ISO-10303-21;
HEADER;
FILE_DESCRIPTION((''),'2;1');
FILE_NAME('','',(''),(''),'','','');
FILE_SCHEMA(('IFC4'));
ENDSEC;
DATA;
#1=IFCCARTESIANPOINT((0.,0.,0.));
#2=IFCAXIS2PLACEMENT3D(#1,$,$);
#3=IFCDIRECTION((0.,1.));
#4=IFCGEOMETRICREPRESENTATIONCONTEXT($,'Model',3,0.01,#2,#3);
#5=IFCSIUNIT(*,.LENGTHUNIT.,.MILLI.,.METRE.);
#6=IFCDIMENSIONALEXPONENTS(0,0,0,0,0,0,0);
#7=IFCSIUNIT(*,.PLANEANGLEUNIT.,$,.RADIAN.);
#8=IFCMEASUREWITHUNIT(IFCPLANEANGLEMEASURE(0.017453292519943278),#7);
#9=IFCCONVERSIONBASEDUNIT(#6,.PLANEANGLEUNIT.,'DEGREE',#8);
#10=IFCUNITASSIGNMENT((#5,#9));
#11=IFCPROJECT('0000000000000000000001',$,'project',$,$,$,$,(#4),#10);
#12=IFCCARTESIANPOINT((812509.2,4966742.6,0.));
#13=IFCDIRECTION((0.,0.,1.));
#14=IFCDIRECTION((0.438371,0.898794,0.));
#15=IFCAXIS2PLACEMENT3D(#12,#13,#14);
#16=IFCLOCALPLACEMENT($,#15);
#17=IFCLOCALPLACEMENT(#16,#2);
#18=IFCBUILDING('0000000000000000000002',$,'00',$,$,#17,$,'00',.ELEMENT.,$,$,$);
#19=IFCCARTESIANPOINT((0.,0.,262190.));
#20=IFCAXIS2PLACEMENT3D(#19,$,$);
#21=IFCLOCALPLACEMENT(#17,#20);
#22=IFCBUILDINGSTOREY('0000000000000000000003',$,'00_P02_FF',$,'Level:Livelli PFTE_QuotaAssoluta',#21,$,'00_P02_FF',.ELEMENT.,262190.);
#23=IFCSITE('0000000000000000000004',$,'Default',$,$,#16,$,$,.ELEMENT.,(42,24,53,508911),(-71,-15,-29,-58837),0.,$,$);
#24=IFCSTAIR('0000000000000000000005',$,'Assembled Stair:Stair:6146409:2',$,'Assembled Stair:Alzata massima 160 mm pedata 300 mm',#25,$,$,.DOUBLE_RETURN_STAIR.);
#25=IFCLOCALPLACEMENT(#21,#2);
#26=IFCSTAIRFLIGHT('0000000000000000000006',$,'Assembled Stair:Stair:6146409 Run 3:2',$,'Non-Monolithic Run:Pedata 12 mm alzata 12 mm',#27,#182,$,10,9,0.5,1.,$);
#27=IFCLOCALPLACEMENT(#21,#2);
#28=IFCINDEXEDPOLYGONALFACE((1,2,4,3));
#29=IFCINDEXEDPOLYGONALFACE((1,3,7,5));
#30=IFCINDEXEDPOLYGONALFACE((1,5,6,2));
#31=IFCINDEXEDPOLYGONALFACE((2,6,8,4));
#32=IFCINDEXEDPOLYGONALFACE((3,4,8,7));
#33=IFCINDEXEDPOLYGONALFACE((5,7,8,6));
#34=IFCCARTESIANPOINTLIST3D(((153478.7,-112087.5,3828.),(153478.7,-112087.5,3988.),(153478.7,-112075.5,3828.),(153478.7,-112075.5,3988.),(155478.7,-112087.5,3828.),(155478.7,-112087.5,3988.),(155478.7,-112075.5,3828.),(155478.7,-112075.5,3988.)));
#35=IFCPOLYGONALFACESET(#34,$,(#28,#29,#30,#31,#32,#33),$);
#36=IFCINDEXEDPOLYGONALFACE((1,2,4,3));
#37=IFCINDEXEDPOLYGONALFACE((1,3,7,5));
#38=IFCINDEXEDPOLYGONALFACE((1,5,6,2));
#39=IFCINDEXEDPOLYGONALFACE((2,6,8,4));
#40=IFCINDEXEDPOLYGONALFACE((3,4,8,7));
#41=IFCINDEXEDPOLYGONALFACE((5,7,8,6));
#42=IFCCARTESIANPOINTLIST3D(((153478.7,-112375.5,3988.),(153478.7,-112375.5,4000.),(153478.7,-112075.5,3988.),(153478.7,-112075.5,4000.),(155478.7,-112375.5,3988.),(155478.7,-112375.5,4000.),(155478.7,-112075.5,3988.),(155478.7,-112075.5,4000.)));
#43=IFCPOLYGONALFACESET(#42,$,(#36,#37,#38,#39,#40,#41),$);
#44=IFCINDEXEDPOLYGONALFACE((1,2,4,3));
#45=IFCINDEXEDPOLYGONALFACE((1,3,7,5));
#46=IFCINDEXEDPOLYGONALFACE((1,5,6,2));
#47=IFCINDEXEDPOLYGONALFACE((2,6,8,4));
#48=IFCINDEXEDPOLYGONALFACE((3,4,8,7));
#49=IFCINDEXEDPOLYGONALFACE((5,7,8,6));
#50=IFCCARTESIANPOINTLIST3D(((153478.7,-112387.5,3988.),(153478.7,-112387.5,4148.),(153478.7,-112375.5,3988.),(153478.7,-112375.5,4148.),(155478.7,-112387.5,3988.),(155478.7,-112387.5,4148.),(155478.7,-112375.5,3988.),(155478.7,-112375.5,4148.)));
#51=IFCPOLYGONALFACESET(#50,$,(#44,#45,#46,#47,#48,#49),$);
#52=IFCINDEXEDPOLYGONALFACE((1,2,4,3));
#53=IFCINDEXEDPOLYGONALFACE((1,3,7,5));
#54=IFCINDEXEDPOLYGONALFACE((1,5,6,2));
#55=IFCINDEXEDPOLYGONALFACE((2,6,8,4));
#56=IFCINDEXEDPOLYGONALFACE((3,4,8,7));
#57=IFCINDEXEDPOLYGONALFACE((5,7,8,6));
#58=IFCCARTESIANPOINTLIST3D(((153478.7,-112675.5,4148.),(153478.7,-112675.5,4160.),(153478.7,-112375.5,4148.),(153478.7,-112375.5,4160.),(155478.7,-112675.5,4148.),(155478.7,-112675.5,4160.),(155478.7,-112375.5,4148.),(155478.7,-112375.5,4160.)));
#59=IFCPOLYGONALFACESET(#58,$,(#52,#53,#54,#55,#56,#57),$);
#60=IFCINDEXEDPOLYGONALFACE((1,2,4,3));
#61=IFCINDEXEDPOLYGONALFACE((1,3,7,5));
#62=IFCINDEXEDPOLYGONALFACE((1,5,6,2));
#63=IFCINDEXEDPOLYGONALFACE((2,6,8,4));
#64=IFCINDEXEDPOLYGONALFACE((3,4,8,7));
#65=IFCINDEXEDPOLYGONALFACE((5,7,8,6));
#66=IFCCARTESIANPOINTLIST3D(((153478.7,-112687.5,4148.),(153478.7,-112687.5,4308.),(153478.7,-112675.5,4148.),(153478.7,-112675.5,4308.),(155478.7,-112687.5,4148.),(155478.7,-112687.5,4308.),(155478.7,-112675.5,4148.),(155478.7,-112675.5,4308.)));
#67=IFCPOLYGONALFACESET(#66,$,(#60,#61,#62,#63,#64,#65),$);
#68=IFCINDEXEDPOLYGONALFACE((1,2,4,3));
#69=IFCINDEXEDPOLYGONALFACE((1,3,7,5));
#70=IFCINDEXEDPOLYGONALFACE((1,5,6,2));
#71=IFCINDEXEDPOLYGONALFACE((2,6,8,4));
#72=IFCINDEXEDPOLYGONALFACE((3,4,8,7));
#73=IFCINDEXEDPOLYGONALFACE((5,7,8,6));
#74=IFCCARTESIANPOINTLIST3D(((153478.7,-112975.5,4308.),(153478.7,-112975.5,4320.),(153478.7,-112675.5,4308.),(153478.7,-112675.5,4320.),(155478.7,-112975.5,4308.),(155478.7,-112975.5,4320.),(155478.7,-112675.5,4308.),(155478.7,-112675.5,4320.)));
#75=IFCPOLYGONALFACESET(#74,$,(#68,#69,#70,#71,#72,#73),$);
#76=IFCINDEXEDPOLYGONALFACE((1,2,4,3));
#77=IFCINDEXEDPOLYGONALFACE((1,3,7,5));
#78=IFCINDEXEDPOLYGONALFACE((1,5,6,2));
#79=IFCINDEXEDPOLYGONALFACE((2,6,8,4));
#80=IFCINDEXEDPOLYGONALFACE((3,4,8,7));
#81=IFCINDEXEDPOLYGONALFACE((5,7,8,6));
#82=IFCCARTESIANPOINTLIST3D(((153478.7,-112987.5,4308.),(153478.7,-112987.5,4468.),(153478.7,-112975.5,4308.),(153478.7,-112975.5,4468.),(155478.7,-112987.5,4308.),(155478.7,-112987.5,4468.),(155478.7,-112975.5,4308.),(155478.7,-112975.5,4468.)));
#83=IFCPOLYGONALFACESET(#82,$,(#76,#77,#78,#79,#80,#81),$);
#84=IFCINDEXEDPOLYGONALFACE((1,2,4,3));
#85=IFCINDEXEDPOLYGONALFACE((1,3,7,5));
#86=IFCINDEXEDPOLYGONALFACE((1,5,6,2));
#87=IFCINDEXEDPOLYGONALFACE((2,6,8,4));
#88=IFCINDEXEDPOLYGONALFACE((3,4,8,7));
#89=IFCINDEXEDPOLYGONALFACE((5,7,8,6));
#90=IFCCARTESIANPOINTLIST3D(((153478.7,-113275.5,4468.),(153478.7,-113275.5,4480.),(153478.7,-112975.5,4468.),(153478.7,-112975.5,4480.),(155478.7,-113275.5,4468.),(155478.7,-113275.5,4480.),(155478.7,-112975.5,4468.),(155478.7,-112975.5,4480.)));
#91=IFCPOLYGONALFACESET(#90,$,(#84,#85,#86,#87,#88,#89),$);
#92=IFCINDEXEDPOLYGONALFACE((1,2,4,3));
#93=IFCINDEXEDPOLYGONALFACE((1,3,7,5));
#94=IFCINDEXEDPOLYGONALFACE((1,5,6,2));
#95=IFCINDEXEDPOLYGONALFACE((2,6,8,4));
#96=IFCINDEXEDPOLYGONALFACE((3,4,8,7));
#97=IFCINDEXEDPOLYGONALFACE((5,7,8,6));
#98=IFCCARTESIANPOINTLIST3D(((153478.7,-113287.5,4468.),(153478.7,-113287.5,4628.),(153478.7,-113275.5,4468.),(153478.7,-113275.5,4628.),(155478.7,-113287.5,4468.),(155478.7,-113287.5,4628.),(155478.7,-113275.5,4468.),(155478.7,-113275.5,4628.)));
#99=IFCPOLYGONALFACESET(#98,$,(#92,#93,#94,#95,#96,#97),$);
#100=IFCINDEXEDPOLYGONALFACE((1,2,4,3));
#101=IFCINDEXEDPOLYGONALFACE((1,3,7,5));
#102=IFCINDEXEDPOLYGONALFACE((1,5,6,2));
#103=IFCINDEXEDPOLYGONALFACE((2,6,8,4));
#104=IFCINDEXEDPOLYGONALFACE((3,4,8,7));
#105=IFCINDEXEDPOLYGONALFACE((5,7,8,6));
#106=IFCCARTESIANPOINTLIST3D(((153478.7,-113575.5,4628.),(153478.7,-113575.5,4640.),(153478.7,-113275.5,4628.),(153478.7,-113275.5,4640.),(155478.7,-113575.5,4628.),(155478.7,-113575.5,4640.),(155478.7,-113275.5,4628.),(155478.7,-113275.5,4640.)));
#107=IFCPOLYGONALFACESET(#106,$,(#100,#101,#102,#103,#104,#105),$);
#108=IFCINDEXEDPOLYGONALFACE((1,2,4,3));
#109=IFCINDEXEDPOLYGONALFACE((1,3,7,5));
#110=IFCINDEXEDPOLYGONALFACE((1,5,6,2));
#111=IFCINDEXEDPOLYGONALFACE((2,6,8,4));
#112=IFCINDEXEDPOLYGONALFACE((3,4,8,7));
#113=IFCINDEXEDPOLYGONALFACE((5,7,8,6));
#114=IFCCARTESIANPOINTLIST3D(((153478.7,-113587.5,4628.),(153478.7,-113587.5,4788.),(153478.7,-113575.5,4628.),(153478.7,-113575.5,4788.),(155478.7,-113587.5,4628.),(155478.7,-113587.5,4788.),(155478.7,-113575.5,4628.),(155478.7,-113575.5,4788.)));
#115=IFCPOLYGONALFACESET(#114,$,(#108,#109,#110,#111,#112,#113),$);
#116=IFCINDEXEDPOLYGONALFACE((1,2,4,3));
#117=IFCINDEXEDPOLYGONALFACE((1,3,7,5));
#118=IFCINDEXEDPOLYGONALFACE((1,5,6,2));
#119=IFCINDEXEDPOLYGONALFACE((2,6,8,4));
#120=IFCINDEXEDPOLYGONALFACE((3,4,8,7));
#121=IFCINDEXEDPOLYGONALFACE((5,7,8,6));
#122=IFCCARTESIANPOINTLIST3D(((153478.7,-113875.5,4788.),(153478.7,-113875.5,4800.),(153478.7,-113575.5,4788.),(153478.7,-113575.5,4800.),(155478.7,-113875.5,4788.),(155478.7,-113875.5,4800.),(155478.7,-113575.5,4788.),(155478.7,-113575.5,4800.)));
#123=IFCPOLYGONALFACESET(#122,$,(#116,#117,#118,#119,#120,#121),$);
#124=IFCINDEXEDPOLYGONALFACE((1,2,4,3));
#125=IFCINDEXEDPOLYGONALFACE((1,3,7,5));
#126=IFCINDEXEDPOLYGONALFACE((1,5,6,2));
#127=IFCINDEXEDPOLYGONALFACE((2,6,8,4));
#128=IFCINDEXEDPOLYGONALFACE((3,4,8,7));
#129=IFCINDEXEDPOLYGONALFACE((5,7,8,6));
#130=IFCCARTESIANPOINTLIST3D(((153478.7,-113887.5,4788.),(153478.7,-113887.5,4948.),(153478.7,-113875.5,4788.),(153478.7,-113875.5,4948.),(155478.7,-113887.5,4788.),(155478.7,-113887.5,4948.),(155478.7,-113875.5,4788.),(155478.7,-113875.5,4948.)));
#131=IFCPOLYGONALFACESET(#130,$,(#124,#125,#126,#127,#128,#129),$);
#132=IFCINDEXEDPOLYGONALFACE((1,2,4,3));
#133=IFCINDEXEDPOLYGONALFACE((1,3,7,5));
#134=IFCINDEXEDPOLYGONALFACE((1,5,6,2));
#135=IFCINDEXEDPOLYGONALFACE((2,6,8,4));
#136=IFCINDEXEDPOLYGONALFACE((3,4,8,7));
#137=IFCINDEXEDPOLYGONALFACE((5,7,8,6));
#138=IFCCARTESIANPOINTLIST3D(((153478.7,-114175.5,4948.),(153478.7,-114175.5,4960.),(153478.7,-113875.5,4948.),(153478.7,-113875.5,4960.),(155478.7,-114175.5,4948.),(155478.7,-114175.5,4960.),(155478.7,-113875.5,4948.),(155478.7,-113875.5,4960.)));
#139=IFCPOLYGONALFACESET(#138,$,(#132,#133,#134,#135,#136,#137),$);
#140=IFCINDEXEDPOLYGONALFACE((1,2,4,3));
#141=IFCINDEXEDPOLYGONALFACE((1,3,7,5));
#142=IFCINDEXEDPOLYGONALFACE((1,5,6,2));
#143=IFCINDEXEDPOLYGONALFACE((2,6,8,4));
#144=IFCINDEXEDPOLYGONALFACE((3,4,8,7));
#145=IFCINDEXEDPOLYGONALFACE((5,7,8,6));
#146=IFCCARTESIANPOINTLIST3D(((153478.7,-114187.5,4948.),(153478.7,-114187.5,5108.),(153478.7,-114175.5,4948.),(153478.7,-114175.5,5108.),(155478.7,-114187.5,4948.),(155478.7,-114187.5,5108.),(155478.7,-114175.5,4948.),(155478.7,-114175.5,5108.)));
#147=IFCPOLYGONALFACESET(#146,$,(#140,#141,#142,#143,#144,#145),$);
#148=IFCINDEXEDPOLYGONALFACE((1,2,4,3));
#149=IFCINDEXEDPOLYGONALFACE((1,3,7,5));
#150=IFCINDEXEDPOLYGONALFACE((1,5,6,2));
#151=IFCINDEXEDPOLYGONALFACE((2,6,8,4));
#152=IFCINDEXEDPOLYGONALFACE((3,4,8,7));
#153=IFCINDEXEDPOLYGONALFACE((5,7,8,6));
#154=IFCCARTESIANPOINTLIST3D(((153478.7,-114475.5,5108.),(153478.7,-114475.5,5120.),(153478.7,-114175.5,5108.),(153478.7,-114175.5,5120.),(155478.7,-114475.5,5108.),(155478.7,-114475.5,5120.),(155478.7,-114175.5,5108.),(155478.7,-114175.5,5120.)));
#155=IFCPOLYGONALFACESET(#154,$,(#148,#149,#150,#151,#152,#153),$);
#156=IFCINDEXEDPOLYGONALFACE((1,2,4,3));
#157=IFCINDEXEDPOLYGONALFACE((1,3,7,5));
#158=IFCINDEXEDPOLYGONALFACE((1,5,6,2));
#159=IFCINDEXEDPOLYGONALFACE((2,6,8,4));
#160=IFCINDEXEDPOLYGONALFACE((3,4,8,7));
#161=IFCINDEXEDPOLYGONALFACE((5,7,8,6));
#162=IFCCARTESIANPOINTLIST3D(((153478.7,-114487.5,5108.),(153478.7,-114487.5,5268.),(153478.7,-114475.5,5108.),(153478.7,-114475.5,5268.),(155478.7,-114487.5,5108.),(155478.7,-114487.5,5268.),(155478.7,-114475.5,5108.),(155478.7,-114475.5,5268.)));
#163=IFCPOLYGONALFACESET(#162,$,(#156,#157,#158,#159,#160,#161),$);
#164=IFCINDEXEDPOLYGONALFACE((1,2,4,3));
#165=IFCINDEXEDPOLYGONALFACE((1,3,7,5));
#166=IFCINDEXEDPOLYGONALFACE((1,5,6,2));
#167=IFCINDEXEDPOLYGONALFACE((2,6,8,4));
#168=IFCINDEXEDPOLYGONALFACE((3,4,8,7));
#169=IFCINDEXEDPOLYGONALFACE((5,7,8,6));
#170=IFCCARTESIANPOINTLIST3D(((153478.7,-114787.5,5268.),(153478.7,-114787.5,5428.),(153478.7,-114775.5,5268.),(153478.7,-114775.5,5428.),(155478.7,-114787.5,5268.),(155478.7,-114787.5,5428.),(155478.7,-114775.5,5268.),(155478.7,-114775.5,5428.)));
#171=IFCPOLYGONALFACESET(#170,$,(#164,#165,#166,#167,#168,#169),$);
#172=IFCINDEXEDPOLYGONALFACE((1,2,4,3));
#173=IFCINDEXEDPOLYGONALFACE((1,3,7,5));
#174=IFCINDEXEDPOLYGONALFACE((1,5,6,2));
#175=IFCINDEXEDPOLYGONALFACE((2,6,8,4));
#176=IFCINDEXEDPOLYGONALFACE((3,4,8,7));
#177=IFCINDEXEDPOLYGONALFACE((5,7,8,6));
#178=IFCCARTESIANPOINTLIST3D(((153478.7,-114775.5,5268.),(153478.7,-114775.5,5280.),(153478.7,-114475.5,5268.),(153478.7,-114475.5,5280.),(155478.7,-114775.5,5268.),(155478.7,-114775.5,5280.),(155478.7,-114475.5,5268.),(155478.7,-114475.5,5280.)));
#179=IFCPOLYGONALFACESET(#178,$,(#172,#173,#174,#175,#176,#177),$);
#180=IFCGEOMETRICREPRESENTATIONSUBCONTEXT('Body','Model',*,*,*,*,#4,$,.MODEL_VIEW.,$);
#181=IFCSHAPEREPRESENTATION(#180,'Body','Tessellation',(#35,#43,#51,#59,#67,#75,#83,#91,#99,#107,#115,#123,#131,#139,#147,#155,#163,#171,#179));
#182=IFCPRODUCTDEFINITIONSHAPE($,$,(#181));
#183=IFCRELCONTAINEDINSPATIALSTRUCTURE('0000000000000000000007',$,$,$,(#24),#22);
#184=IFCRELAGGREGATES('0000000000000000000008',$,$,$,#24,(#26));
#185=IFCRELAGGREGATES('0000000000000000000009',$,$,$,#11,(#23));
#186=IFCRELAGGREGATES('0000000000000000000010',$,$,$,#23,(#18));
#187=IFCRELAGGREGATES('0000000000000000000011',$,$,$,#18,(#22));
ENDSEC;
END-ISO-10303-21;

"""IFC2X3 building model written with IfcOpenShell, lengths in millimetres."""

from ifc_helpers import new_model, entity, si_unit, converted_unit, direction, frame, frame_2d, origin, origin_2d_with_axis, place, context, subcontext, project, spatial, rectangle, extrude, element, aggregate, save


model = new_model("IFC2X3")

# Units and contexts
model_context = context("Model", 3, precision=0.01, world=origin(), true_north=direction((0.0, 1.0)))
body_context = subcontext(model_context, "Body", "Model", "MODEL_VIEW")
ifc_project = project(units=[si_unit("LENGTHUNIT", "METRE", prefix="MILLI"), converted_unit("PLANEANGLEUNIT", "DEGREE", entity("IfcPlaneAngleMeasure", 0.017453292519943278), si_unit("PLANEANGLEUNIT", "RADIAN"), dimensions=[0, 0, 0, 0, 0, 0, 0])], contexts=[model_context])

# Site, building, storey
site_placement = place(None, frame((812509.2, 4966742.6, 0.0), z_axis=(0.0, 0.0, 1.0), x_axis=(0.438371, 0.898794, 0.0)))
site = spatial("IfcSite", under=ifc_project, at=site_placement, Name="Default", CompositionType="ELEMENT", RefLatitude=(42, 24, 53, 508911), RefLongitude=(-71, -15, -29, -58837), RefElevation=0.0)
building_placement = place(site_placement, origin())
building = spatial("IfcBuilding", under=site, at=building_placement, Name="00", LongName="00", CompositionType="ELEMENT")
storey_placement = place(building_placement, frame((0.0, 0.0, 262190.0)))
storey = spatial("IfcBuildingStorey", under=building, at=storey_placement, Name="00_P02_FF", ObjectType="Level:Livelli PFTE_QuotaAssoluta", LongName="00_P02_FF", CompositionType="ELEMENT", Elevation=262190.0)

# Stair
stair_1_placement = place(storey_placement, origin())
stair_1 = element("IfcStair", 1, at=stair_1_placement, inside=storey, Name="Assembled Stair:Stair:6146409:2", ObjectType="Assembled Stair:Alzata massima 160 mm pedata 300 mm", ShapeType="DOUBLE_RETURN_STAIR")

# Stair flight
stair_flight_1_placement = place(stair_1_placement, origin())
stair_flight_1 = element("IfcStairFlight", 2, at=stair_flight_1_placement, Name="Assembled Stair:Stair:6146409 Run 3:2", ObjectType="Non-Monolithic Run:Pedata 12 mm alzata 12 mm", NumberOfRiser=10, NumberOfTreads=9, RiserHeight=0.5, TreadLength=1.0, context=body_context, shape_type="SweptSolid", body=[
    extrude(rectangle(XDim=2000.0, YDim=12.0, at=origin_2d_with_axis()), frame((154478.7, -112081.5, 3828.0)), (0.0, 0.0, 1.0), 160.0),
    extrude(rectangle(XDim=300.0, YDim=2000.0, at=origin_2d_with_axis()), frame((154478.7, -112225.5, 3988.0), z_axis=(0.0, 0.0, 1.0), x_axis=(0.0, 1.0, 0.0)), (0.0, 0.0, 1.0), 12.0),
    extrude(rectangle(XDim=2000.0, YDim=12.0, at=origin_2d_with_axis()), frame((154478.7, -112381.5, 3988.0)), (0.0, 0.0, 1.0), 160.0),
    extrude(rectangle(XDim=300.0, YDim=2000.0, at=frame_2d((0.0, 0.0), x_axis=(1.0, 0.0))), frame((154478.7, -112525.5, 4148.0), z_axis=(0.0, 0.0, 1.0), x_axis=(0.0, 1.0, 0.0)), (0.0, 0.0, 1.0), 12.0),
    extrude(rectangle(XDim=2000.0, YDim=12.0, at=frame_2d((0.0, 0.0), x_axis=(1.0, 0.0))), frame((154478.7, -112681.5, 4148.0)), (0.0, 0.0, 1.0), 160.0),
    extrude(rectangle(XDim=300.0, YDim=2000.0, at=frame_2d((0.0, 0.0), x_axis=(1.0, 0.0))), frame((154478.7, -112825.5, 4308.0), z_axis=(0.0, 0.0, 1.0), x_axis=(0.0, 1.0, 0.0)), (0.0, 0.0, 1.0), 12.0),
    extrude(rectangle(XDim=2000.0, YDim=12.0, at=frame_2d((0.0, 0.0), x_axis=(1.0, 0.0))), frame((154478.7, -112981.5, 4308.0)), (0.0, 0.0, 1.0), 160.0),
    extrude(rectangle(XDim=300.0, YDim=2000.0, at=frame_2d((0.0, 0.0), x_axis=(1.0, 0.0))), frame((154478.7, -113125.5, 4468.0), z_axis=(0.0, 0.0, 1.0), x_axis=(0.0, 1.0, 0.0)), (0.0, 0.0, 1.0), 12.0),
    extrude(rectangle(XDim=2000.0, YDim=12.0, at=frame_2d((0.0, 0.0), x_axis=(1.0, 0.0))), frame((154478.7, -113281.5, 4468.0)), (0.0, 0.0, 1.0), 160.0),
    extrude(rectangle(XDim=300.0, YDim=2000.0, at=frame_2d((0.0, 0.0), x_axis=(1.0, 0.0))), frame((154478.7, -113425.5, 4628.0), z_axis=(0.0, 0.0, 1.0), x_axis=(0.0, 1.0, 0.0)), (0.0, 0.0, 1.0), 12.0),
    extrude(rectangle(XDim=2000.0, YDim=12.0, at=frame_2d((0.0, 0.0), x_axis=(1.0, 0.0))), frame((154478.7, -113581.5, 4628.0)), (0.0, 0.0, 1.0), 160.0),
    extrude(rectangle(XDim=300.0, YDim=2000.0, at=frame_2d((0.0, 0.0), x_axis=(1.0, 0.0))), frame((154478.7, -113725.5, 4788.0), z_axis=(0.0, 0.0, 1.0), x_axis=(0.0, 1.0, 0.0)), (0.0, 0.0, 1.0), 12.0),
    extrude(rectangle(XDim=2000.0, YDim=12.0, at=origin_2d_with_axis()), frame((154478.7, -113881.5, 4788.0)), (0.0, 0.0, 1.0), 160.0),
    extrude(rectangle(XDim=300.0, YDim=2000.0, at=frame_2d((0.0, 0.0), x_axis=(1.0, 0.0))), frame((154478.7, -114025.5, 4948.0), z_axis=(0.0, 0.0, 1.0), x_axis=(0.0, 1.0, 0.0)), (0.0, 0.0, 1.0), 12.0),
    extrude(rectangle(XDim=2000.0, YDim=12.0, at=origin_2d_with_axis()), frame((154478.7, -114181.5, 4948.0)), (0.0, 0.0, 1.0), 160.0),
    extrude(rectangle(XDim=300.0, YDim=2000.0, at=frame_2d((0.0, 0.0), x_axis=(1.0, 0.0))), frame((154478.7, -114325.5, 5108.0), z_axis=(0.0, 0.0, 1.0), x_axis=(0.0, 1.0, 0.0)), (0.0, 0.0, 1.0), 12.0),
    extrude(rectangle(XDim=2000.0, YDim=12.0, at=origin_2d_with_axis()), frame((154478.7, -114481.5, 5108.0)), (0.0, 0.0, 1.0), 160.0),
    extrude(rectangle(XDim=2000.0, YDim=12.0, at=origin_2d_with_axis()), frame((154478.7, -114781.5, 5268.0)), (0.0, 0.0, 1.0), 160.0),
    extrude(rectangle(XDim=300.0, YDim=2000.0, at=frame_2d((0.0, 0.0), x_axis=(1.0, 0.0))), frame((154478.7, -114625.5, 5268.0), z_axis=(0.0, 0.0, 1.0), x_axis=(0.0, 1.0, 0.0)), (0.0, 0.0, 1.0), 12.0),
])
aggregate(stair_1, [stair_flight_1])

save(model, "model.ifc")
